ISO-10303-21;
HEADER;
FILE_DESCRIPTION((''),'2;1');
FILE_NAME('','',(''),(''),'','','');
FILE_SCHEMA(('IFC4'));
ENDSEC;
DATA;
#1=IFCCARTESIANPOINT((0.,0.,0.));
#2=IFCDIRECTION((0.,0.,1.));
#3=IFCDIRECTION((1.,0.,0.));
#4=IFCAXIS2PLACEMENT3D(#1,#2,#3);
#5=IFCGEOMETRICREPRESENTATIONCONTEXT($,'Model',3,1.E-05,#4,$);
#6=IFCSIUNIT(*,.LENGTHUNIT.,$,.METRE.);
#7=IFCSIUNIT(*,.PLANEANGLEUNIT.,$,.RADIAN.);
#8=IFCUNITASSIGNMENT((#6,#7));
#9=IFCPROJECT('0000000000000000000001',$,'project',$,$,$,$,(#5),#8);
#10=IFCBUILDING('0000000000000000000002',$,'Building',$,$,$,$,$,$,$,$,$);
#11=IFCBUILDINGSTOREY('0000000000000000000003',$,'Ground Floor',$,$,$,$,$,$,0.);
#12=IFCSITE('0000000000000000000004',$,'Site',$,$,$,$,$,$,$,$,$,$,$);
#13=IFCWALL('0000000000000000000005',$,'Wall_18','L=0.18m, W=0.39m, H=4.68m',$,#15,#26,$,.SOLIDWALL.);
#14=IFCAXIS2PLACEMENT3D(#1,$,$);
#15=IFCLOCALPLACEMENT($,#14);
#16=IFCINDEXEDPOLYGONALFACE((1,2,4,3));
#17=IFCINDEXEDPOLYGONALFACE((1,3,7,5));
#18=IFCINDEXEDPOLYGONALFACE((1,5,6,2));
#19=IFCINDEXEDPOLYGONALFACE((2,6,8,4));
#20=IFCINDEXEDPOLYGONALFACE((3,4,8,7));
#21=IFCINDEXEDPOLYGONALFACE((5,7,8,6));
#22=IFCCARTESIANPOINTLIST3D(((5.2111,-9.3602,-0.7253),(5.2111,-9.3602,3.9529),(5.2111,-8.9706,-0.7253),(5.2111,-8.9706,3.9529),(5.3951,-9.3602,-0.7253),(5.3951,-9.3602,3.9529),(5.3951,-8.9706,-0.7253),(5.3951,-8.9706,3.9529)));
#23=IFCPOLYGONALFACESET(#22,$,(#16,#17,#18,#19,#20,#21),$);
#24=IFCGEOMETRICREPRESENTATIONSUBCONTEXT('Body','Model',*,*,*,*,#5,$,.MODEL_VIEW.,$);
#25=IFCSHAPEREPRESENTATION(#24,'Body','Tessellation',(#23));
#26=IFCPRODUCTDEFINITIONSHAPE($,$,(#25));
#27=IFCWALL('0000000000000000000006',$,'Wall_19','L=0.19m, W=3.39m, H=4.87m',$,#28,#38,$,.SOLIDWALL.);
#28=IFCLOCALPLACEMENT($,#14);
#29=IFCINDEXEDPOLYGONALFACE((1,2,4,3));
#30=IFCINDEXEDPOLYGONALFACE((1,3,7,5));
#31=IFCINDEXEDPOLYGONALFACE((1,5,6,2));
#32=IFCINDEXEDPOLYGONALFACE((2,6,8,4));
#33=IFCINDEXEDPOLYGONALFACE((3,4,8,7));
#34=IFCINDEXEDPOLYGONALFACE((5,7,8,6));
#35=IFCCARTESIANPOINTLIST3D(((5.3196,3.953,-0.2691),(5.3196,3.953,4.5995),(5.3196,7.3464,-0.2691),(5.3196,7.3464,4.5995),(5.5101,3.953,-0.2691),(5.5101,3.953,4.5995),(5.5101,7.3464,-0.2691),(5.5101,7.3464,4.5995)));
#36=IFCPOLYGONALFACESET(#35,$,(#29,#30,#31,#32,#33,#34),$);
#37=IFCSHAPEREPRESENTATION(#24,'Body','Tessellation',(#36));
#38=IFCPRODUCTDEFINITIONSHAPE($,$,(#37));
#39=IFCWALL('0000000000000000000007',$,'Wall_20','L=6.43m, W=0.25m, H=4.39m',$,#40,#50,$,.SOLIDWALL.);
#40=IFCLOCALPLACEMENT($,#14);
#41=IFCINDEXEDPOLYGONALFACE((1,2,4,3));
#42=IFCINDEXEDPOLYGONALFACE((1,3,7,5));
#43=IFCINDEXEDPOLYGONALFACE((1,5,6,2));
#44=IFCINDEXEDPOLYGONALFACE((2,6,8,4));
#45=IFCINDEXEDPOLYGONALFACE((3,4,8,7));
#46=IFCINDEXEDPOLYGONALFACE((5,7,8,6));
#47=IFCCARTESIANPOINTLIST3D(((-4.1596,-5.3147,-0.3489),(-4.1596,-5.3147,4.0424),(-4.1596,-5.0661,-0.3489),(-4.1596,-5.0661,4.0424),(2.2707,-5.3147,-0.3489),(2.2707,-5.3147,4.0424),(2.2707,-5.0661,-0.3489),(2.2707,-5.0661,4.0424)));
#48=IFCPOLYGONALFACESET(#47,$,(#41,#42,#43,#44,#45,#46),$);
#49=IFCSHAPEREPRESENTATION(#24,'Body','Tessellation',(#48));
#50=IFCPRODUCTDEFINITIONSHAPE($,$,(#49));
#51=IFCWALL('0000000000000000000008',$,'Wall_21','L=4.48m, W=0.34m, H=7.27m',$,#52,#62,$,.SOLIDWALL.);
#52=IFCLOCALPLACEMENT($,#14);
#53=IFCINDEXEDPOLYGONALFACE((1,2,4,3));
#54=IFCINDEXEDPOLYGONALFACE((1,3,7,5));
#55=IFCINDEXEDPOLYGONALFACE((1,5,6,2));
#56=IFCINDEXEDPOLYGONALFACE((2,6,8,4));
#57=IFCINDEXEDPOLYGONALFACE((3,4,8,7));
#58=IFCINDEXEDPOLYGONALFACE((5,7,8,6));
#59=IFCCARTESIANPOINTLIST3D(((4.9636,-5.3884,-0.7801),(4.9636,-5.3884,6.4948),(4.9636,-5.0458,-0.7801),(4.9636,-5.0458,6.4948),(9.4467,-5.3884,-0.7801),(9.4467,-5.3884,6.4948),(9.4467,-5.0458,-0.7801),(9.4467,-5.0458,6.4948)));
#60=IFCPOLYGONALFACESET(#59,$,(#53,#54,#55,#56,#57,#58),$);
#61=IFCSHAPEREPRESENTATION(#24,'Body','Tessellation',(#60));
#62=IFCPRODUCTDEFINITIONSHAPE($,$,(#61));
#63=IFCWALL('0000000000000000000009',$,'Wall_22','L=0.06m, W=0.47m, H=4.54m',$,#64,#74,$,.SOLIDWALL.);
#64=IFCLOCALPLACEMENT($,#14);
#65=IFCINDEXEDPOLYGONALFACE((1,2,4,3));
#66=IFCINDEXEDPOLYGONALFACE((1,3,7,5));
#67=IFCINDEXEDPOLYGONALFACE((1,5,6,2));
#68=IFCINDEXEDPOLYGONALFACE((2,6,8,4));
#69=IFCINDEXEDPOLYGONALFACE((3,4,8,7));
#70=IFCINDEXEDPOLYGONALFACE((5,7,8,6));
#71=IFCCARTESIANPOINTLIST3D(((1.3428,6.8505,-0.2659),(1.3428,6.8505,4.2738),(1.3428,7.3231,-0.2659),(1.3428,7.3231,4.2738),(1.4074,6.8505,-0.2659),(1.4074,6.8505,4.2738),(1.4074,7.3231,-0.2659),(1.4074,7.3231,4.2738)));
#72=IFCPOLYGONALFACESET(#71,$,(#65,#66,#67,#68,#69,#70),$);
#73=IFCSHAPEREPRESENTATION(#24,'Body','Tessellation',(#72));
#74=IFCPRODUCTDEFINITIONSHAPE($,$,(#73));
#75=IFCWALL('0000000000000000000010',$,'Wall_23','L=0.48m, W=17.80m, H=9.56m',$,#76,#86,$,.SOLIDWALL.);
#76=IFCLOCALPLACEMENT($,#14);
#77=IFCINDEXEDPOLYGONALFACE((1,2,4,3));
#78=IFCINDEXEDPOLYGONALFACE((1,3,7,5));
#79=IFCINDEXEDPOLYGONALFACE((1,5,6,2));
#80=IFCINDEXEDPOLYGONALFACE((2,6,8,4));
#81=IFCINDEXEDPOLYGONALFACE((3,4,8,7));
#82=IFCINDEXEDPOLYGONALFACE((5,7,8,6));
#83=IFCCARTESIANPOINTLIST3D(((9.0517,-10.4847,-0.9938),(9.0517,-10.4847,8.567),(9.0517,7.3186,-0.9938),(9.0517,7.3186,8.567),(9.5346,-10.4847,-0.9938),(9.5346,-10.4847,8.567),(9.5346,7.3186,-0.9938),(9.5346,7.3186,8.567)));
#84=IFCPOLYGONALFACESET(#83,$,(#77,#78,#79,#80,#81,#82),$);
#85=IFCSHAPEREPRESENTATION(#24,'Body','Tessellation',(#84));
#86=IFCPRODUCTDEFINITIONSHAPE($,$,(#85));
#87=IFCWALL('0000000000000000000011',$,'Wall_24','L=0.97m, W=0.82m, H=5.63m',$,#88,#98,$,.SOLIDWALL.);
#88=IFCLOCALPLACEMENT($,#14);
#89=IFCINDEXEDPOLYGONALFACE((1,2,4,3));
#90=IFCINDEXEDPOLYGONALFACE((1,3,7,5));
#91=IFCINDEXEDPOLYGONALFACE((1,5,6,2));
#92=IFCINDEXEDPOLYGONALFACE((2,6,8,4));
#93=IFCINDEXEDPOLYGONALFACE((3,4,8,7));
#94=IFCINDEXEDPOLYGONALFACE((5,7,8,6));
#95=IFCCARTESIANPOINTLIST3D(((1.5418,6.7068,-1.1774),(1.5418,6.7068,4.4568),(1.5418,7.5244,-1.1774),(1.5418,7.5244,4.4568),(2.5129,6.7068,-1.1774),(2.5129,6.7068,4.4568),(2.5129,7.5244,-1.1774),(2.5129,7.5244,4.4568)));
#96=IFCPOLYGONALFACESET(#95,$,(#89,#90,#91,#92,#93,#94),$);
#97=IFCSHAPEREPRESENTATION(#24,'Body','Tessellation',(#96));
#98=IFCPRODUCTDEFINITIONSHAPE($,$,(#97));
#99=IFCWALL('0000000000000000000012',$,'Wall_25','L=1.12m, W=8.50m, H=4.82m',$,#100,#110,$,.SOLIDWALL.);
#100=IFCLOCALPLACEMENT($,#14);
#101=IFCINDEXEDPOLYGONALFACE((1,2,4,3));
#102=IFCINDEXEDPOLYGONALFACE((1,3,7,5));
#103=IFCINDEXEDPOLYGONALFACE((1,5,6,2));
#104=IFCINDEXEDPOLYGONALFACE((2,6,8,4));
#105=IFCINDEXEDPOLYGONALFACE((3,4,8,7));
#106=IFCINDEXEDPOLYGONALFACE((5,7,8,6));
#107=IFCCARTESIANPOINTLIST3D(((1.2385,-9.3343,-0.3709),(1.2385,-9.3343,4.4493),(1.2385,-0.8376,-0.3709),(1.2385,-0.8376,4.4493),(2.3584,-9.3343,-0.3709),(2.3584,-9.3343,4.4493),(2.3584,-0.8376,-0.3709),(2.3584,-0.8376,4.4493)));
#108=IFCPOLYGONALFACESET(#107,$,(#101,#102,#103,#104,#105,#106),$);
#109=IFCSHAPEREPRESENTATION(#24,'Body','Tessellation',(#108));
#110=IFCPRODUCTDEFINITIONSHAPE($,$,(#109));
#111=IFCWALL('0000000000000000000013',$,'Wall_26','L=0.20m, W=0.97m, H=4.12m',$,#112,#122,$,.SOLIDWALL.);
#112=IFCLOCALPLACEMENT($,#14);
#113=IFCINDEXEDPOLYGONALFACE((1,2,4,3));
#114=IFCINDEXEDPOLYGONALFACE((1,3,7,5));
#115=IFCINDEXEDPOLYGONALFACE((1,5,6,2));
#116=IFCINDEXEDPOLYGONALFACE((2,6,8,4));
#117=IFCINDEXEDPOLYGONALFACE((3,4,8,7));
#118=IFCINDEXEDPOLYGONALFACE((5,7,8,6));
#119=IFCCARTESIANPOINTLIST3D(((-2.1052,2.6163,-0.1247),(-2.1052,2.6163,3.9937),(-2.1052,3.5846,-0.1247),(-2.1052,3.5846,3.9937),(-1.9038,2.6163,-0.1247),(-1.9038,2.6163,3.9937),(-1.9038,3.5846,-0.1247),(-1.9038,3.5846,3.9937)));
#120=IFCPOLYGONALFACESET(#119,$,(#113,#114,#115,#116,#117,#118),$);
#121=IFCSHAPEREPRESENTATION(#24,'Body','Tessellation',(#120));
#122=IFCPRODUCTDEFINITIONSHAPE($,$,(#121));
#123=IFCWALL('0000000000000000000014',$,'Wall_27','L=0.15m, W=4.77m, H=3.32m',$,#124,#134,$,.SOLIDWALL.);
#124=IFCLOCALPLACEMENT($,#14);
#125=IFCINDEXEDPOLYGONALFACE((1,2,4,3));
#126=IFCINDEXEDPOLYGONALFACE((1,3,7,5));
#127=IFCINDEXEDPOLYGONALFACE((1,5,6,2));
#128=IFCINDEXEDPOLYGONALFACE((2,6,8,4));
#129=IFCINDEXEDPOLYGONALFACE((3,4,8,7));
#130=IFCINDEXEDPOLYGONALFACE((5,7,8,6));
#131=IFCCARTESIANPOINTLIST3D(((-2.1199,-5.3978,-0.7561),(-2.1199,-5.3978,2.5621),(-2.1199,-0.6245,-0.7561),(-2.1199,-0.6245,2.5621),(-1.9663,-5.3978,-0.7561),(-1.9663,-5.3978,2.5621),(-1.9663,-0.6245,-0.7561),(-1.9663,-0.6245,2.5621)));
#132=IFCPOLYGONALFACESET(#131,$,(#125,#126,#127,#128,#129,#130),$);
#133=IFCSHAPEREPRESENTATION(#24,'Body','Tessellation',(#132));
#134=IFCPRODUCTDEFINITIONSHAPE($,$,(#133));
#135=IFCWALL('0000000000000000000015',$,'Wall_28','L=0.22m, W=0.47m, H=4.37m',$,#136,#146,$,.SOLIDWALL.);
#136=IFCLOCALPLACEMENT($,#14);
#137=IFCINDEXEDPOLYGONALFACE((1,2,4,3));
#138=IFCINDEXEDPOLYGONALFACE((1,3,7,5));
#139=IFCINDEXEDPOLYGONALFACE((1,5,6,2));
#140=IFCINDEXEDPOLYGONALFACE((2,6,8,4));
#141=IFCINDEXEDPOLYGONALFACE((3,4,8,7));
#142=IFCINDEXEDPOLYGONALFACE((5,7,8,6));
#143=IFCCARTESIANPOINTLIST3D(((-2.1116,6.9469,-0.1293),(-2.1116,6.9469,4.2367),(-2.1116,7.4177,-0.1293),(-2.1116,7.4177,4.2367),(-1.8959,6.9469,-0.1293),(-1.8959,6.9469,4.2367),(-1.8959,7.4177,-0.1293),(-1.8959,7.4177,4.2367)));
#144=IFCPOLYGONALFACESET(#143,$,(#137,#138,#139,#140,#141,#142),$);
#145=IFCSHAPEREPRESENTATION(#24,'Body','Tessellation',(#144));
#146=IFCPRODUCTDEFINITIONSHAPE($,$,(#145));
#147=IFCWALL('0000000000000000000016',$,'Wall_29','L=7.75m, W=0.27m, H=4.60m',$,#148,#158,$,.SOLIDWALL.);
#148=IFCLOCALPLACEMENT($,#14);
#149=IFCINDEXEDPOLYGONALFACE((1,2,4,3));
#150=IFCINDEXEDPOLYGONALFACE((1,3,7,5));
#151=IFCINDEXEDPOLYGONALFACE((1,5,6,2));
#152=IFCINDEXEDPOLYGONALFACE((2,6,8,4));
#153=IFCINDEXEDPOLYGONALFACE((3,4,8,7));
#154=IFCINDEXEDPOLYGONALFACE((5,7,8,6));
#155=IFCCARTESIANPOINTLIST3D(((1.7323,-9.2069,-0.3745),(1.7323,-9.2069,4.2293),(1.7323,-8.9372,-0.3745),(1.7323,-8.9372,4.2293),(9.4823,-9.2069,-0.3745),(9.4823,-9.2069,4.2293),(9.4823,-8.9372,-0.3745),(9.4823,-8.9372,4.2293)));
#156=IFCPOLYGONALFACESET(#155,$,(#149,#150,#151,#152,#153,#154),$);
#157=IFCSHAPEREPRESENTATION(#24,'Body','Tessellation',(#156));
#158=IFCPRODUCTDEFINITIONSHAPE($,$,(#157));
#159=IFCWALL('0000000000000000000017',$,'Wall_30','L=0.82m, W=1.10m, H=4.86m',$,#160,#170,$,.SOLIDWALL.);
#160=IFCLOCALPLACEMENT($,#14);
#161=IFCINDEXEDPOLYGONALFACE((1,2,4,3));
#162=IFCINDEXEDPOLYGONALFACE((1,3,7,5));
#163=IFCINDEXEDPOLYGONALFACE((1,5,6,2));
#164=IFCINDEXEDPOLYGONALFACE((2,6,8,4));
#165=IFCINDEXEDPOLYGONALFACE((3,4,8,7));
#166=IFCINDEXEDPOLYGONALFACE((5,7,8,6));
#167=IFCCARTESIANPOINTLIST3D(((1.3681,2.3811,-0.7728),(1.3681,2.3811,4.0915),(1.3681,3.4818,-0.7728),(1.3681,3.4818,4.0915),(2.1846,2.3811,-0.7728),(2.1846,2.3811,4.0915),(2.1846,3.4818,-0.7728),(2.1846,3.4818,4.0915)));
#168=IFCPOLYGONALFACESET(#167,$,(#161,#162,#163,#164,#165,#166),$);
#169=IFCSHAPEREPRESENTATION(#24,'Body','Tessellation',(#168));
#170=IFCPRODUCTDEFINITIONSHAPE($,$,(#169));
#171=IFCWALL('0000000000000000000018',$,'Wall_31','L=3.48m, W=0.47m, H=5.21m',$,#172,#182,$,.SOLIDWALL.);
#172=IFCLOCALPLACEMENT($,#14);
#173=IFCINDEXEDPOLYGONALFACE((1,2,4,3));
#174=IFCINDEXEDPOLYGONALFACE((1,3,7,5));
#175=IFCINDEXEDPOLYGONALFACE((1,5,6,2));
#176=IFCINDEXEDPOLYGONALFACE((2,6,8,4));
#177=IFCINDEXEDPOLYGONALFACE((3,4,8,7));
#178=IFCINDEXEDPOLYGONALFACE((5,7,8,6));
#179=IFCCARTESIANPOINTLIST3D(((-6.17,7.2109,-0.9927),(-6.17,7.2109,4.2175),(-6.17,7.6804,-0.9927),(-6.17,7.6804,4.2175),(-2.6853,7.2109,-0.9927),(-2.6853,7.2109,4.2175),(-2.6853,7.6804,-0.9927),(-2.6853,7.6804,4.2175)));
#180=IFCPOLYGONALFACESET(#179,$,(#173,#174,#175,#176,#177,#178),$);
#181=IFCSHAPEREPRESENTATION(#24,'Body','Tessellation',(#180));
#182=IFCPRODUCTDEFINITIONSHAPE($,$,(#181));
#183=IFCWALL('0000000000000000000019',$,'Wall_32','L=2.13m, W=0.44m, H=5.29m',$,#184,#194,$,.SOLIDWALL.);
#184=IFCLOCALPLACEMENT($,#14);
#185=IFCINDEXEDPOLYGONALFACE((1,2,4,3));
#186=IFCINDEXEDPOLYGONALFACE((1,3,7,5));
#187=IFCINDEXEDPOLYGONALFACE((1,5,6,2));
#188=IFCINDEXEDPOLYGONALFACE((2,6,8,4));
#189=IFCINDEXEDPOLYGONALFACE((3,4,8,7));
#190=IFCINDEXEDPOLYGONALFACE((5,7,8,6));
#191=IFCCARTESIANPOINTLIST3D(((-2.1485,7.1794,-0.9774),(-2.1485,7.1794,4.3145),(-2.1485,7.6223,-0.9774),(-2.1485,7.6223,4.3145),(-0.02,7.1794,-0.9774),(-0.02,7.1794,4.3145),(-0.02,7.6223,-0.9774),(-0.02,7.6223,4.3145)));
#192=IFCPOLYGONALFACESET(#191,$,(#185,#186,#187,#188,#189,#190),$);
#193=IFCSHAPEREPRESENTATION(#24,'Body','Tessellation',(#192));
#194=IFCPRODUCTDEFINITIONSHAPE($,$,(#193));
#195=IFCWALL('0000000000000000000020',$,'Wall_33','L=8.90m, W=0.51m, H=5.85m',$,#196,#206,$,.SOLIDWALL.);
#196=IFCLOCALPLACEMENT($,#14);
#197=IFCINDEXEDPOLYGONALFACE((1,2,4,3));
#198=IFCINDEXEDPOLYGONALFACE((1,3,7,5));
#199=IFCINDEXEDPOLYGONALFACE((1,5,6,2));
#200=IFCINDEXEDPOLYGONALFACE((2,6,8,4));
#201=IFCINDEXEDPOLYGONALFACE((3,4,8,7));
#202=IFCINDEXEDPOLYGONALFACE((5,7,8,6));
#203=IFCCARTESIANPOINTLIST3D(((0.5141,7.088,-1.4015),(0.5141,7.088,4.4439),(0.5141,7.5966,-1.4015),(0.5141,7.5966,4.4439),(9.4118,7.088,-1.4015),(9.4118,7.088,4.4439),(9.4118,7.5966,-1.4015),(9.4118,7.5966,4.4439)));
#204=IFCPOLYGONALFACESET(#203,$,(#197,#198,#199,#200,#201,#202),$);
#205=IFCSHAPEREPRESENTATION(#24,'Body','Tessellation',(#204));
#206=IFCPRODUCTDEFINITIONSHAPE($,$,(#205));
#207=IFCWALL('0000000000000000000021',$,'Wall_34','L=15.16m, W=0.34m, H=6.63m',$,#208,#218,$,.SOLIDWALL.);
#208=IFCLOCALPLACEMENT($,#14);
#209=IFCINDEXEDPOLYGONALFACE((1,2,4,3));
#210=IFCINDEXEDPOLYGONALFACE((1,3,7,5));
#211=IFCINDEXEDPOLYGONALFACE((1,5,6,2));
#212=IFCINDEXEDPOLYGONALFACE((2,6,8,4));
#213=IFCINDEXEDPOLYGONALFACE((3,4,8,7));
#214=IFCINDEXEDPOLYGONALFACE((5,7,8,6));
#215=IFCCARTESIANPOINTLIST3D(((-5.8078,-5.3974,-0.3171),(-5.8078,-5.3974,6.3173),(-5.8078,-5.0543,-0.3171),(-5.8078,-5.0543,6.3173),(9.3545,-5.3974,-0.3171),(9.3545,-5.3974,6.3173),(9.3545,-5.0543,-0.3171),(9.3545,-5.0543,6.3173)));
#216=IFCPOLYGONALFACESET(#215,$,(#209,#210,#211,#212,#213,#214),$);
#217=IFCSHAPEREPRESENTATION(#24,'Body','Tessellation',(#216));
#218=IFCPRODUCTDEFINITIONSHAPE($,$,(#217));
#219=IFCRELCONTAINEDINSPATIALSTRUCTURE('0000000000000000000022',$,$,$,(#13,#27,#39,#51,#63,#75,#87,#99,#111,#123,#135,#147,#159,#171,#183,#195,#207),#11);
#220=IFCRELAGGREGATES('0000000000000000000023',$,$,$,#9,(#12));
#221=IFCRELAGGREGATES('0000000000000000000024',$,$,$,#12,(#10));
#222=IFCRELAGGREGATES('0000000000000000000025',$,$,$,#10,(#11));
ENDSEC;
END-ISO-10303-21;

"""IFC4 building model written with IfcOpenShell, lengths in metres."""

from ifc_helpers import new_model, si_unit, frame, origin_with_axes, origin_2d, context, subcontext, project, spatial, rectangle, extrude, element, save


model = new_model("IFC4")

# Units and contexts
model_context = context("Model", 3, precision=1e-05, world=origin_with_axes())
body_context = subcontext(model_context, "Body", "Model", "MODEL_VIEW")
ifc_project = project(units=[si_unit("LENGTHUNIT", "METRE"), si_unit("PLANEANGLEUNIT", "RADIAN")], contexts=[model_context])

# Site, building, storey
site = spatial("IfcSite", under=ifc_project, Name="Site")
building = spatial("IfcBuilding", under=site, Name="Building")
storey = spatial("IfcBuildingStorey", under=building, Name="Ground Floor", Elevation=0.0)

# Walls
element("IfcWall", 1, inside=storey, Name="Wall_18", Description="L=0.18m, W=0.39m, H=4.68m", PredefinedType="SOLIDWALL", context=body_context, shape_type="SweptSolid", body=[
    extrude(rectangle(XDim=0.184, YDim=0.3896, at=origin_2d()), frame((5.3031, -9.1654, -0.7253), z_axis=(0.0, 0.0, 1.0), x_axis=(1.0, 0.0, 0.0)), (0.0, 0.0, 1.0), 4.6782),
])
element("IfcWall", 2, inside=storey, Name="Wall_19", Description="L=0.19m, W=3.39m, H=4.87m", PredefinedType="SOLIDWALL", context=body_context, shape_type="SweptSolid", body=[
    extrude(rectangle(XDim=0.1906, YDim=3.3933, at=origin_2d()), frame((5.4148, 5.6497, -0.2691), z_axis=(0.0, 0.0, 1.0), x_axis=(1.0, 0.0, 0.0)), (0.0, 0.0, 1.0), 4.8686),
])
element("IfcWall", 3, inside=storey, Name="Wall_20", Description="L=6.43m, W=0.25m, H=4.39m", PredefinedType="SOLIDWALL", context=body_context, shape_type="SweptSolid", body=[
    extrude(rectangle(XDim=6.4303, YDim=0.2487, at=origin_2d()), frame((-0.9445, -5.1904, -0.3489), z_axis=(0.0, 0.0, 1.0), x_axis=(1.0, 0.0, 0.0)), (0.0, 0.0, 1.0), 4.3913),
])
element("IfcWall", 4, inside=storey, Name="Wall_21", Description="L=4.48m, W=0.34m, H=7.27m", PredefinedType="SOLIDWALL", context=body_context, shape_type="SweptSolid", body=[
    extrude(rectangle(XDim=4.4831, YDim=0.3426, at=origin_2d()), frame((7.2052, -5.2171, -0.7801), z_axis=(0.0, 0.0, 1.0), x_axis=(1.0, 0.0, 0.0)), (0.0, 0.0, 1.0), 7.2749),
])
element("IfcWall", 5, inside=storey, Name="Wall_22", Description="L=0.06m, W=0.47m, H=4.54m", PredefinedType="SOLIDWALL", context=body_context, shape_type="SweptSolid", body=[
    extrude(rectangle(XDim=0.0646, YDim=0.4726, at=origin_2d()), frame((1.3751, 7.0868, -0.2659), z_axis=(0.0, 0.0, 1.0), x_axis=(1.0, 0.0, 0.0)), (0.0, 0.0, 1.0), 4.5397),
])
element("IfcWall", 6, inside=storey, Name="Wall_23", Description="L=0.48m, W=17.80m, H=9.56m", PredefinedType="SOLIDWALL", context=body_context, shape_type="SweptSolid", body=[
    extrude(rectangle(XDim=0.483, YDim=17.8033, at=origin_2d()), frame((9.2931, -1.5831, -0.9938), z_axis=(0.0, 0.0, 1.0), x_axis=(1.0, 0.0, 0.0)), (0.0, 0.0, 1.0), 9.5608),
])
element("IfcWall", 7, inside=storey, Name="Wall_24", Description="L=0.97m, W=0.82m, H=5.63m", PredefinedType="SOLIDWALL", context=body_context, shape_type="SweptSolid", body=[
    extrude(rectangle(XDim=0.9711, YDim=0.8176, at=origin_2d()), frame((2.0273, 7.1156, -1.1774), z_axis=(0.0, 0.0, 1.0), x_axis=(1.0, 0.0, 0.0)), (0.0, 0.0, 1.0), 5.6342),
])
element("IfcWall", 8, inside=storey, Name="Wall_25", Description="L=1.12m, W=8.50m, H=4.82m", PredefinedType="SOLIDWALL", context=body_context, shape_type="SweptSolid", body=[
    extrude(rectangle(XDim=1.1199, YDim=8.4967, at=origin_2d()), frame((1.7984, -5.086, -0.3709), z_axis=(0.0, 0.0, 1.0), x_axis=(1.0, 0.0, 0.0)), (0.0, 0.0, 1.0), 4.8202),
])
element("IfcWall", 9, inside=storey, Name="Wall_26", Description="L=0.20m, W=0.97m, H=4.12m", PredefinedType="SOLIDWALL", context=body_context, shape_type="SweptSolid", body=[
    extrude(rectangle(XDim=0.2014, YDim=0.9684, at=origin_2d()), frame((-2.0045, 3.1005, -0.1247), z_axis=(0.0, 0.0, 1.0), x_axis=(1.0, 0.0, 0.0)), (0.0, 0.0, 1.0), 4.1184),
])
element("IfcWall", 10, inside=storey, Name="Wall_27", Description="L=0.15m, W=4.77m, H=3.32m", PredefinedType="SOLIDWALL", context=body_context, shape_type="SweptSolid", body=[
    extrude(rectangle(XDim=0.1537, YDim=4.7733, at=origin_2d()), frame((-2.0431, -3.0111, -0.7561), z_axis=(0.0, 0.0, 1.0), x_axis=(1.0, 0.0, 0.0)), (0.0, 0.0, 1.0), 3.3182),
])
element("IfcWall", 11, inside=storey, Name="Wall_28", Description="L=0.22m, W=0.47m, H=4.37m", PredefinedType="SOLIDWALL", context=body_context, shape_type="SweptSolid", body=[
    extrude(rectangle(XDim=0.2157, YDim=0.4708, at=origin_2d()), frame((-2.0037, 7.1823, -0.1293), z_axis=(0.0, 0.0, 1.0), x_axis=(1.0, 0.0, 0.0)), (0.0, 0.0, 1.0), 4.366),
])
element("IfcWall", 12, inside=storey, Name="Wall_29", Description="L=7.75m, W=0.27m, H=4.60m", PredefinedType="SOLIDWALL", context=body_context, shape_type="SweptSolid", body=[
    extrude(rectangle(XDim=7.7499, YDim=0.2697, at=origin_2d()), frame((5.6073, -9.072, -0.3745), z_axis=(0.0, 0.0, 1.0), x_axis=(1.0, 0.0, 0.0)), (0.0, 0.0, 1.0), 4.6038),
])
element("IfcWall", 13, inside=storey, Name="Wall_30", Description="L=0.82m, W=1.10m, H=4.86m", PredefinedType="SOLIDWALL", context=body_context, shape_type="SweptSolid", body=[
    extrude(rectangle(XDim=0.8165, YDim=1.1007, at=origin_2d()), frame((1.7764, 2.9314, -0.7728), z_axis=(0.0, 0.0, 1.0), x_axis=(1.0, 0.0, 0.0)), (0.0, 0.0, 1.0), 4.8643),
])
element("IfcWall", 14, inside=storey, Name="Wall_31", Description="L=3.48m, W=0.47m, H=5.21m", PredefinedType="SOLIDWALL", context=body_context, shape_type="SweptSolid", body=[
    extrude(rectangle(XDim=3.4847, YDim=0.4695, at=origin_2d()), frame((-4.4276, 7.4457, -0.9927), z_axis=(0.0, 0.0, 1.0), x_axis=(1.0, 0.0, 0.0)), (0.0, 0.0, 1.0), 5.2102),
])
element("IfcWall", 15, inside=storey, Name="Wall_32", Description="L=2.13m, W=0.44m, H=5.29m", PredefinedType="SOLIDWALL", context=body_context, shape_type="SweptSolid", body=[
    extrude(rectangle(XDim=2.1285, YDim=0.4429, at=origin_2d()), frame((-1.0842, 7.4009, -0.9774), z_axis=(0.0, 0.0, 1.0), x_axis=(1.0, 0.0, 0.0)), (0.0, 0.0, 1.0), 5.2919),
])
element("IfcWall", 16, inside=storey, Name="Wall_33", Description="L=8.90m, W=0.51m, H=5.85m", PredefinedType="SOLIDWALL", context=body_context, shape_type="SweptSolid", body=[
    extrude(rectangle(XDim=8.8977, YDim=0.5085, at=origin_2d()), frame((4.9629, 7.3423, -1.4015), z_axis=(0.0, 0.0, 1.0), x_axis=(1.0, 0.0, 0.0)), (0.0, 0.0, 1.0), 5.8454),
])
element("IfcWall", 17, inside=storey, Name="Wall_34", Description="L=15.16m, W=0.34m, H=6.63m", PredefinedType="SOLIDWALL", context=body_context, shape_type="SweptSolid", body=[
    extrude(rectangle(XDim=15.1623, YDim=0.3431, at=origin_2d()), frame((1.7733, -5.2258, -0.3171), z_axis=(0.0, 0.0, 1.0), x_axis=(1.0, 0.0, 0.0)), (0.0, 0.0, 1.0), 6.6344),
])

save(model, "model.ifc")
